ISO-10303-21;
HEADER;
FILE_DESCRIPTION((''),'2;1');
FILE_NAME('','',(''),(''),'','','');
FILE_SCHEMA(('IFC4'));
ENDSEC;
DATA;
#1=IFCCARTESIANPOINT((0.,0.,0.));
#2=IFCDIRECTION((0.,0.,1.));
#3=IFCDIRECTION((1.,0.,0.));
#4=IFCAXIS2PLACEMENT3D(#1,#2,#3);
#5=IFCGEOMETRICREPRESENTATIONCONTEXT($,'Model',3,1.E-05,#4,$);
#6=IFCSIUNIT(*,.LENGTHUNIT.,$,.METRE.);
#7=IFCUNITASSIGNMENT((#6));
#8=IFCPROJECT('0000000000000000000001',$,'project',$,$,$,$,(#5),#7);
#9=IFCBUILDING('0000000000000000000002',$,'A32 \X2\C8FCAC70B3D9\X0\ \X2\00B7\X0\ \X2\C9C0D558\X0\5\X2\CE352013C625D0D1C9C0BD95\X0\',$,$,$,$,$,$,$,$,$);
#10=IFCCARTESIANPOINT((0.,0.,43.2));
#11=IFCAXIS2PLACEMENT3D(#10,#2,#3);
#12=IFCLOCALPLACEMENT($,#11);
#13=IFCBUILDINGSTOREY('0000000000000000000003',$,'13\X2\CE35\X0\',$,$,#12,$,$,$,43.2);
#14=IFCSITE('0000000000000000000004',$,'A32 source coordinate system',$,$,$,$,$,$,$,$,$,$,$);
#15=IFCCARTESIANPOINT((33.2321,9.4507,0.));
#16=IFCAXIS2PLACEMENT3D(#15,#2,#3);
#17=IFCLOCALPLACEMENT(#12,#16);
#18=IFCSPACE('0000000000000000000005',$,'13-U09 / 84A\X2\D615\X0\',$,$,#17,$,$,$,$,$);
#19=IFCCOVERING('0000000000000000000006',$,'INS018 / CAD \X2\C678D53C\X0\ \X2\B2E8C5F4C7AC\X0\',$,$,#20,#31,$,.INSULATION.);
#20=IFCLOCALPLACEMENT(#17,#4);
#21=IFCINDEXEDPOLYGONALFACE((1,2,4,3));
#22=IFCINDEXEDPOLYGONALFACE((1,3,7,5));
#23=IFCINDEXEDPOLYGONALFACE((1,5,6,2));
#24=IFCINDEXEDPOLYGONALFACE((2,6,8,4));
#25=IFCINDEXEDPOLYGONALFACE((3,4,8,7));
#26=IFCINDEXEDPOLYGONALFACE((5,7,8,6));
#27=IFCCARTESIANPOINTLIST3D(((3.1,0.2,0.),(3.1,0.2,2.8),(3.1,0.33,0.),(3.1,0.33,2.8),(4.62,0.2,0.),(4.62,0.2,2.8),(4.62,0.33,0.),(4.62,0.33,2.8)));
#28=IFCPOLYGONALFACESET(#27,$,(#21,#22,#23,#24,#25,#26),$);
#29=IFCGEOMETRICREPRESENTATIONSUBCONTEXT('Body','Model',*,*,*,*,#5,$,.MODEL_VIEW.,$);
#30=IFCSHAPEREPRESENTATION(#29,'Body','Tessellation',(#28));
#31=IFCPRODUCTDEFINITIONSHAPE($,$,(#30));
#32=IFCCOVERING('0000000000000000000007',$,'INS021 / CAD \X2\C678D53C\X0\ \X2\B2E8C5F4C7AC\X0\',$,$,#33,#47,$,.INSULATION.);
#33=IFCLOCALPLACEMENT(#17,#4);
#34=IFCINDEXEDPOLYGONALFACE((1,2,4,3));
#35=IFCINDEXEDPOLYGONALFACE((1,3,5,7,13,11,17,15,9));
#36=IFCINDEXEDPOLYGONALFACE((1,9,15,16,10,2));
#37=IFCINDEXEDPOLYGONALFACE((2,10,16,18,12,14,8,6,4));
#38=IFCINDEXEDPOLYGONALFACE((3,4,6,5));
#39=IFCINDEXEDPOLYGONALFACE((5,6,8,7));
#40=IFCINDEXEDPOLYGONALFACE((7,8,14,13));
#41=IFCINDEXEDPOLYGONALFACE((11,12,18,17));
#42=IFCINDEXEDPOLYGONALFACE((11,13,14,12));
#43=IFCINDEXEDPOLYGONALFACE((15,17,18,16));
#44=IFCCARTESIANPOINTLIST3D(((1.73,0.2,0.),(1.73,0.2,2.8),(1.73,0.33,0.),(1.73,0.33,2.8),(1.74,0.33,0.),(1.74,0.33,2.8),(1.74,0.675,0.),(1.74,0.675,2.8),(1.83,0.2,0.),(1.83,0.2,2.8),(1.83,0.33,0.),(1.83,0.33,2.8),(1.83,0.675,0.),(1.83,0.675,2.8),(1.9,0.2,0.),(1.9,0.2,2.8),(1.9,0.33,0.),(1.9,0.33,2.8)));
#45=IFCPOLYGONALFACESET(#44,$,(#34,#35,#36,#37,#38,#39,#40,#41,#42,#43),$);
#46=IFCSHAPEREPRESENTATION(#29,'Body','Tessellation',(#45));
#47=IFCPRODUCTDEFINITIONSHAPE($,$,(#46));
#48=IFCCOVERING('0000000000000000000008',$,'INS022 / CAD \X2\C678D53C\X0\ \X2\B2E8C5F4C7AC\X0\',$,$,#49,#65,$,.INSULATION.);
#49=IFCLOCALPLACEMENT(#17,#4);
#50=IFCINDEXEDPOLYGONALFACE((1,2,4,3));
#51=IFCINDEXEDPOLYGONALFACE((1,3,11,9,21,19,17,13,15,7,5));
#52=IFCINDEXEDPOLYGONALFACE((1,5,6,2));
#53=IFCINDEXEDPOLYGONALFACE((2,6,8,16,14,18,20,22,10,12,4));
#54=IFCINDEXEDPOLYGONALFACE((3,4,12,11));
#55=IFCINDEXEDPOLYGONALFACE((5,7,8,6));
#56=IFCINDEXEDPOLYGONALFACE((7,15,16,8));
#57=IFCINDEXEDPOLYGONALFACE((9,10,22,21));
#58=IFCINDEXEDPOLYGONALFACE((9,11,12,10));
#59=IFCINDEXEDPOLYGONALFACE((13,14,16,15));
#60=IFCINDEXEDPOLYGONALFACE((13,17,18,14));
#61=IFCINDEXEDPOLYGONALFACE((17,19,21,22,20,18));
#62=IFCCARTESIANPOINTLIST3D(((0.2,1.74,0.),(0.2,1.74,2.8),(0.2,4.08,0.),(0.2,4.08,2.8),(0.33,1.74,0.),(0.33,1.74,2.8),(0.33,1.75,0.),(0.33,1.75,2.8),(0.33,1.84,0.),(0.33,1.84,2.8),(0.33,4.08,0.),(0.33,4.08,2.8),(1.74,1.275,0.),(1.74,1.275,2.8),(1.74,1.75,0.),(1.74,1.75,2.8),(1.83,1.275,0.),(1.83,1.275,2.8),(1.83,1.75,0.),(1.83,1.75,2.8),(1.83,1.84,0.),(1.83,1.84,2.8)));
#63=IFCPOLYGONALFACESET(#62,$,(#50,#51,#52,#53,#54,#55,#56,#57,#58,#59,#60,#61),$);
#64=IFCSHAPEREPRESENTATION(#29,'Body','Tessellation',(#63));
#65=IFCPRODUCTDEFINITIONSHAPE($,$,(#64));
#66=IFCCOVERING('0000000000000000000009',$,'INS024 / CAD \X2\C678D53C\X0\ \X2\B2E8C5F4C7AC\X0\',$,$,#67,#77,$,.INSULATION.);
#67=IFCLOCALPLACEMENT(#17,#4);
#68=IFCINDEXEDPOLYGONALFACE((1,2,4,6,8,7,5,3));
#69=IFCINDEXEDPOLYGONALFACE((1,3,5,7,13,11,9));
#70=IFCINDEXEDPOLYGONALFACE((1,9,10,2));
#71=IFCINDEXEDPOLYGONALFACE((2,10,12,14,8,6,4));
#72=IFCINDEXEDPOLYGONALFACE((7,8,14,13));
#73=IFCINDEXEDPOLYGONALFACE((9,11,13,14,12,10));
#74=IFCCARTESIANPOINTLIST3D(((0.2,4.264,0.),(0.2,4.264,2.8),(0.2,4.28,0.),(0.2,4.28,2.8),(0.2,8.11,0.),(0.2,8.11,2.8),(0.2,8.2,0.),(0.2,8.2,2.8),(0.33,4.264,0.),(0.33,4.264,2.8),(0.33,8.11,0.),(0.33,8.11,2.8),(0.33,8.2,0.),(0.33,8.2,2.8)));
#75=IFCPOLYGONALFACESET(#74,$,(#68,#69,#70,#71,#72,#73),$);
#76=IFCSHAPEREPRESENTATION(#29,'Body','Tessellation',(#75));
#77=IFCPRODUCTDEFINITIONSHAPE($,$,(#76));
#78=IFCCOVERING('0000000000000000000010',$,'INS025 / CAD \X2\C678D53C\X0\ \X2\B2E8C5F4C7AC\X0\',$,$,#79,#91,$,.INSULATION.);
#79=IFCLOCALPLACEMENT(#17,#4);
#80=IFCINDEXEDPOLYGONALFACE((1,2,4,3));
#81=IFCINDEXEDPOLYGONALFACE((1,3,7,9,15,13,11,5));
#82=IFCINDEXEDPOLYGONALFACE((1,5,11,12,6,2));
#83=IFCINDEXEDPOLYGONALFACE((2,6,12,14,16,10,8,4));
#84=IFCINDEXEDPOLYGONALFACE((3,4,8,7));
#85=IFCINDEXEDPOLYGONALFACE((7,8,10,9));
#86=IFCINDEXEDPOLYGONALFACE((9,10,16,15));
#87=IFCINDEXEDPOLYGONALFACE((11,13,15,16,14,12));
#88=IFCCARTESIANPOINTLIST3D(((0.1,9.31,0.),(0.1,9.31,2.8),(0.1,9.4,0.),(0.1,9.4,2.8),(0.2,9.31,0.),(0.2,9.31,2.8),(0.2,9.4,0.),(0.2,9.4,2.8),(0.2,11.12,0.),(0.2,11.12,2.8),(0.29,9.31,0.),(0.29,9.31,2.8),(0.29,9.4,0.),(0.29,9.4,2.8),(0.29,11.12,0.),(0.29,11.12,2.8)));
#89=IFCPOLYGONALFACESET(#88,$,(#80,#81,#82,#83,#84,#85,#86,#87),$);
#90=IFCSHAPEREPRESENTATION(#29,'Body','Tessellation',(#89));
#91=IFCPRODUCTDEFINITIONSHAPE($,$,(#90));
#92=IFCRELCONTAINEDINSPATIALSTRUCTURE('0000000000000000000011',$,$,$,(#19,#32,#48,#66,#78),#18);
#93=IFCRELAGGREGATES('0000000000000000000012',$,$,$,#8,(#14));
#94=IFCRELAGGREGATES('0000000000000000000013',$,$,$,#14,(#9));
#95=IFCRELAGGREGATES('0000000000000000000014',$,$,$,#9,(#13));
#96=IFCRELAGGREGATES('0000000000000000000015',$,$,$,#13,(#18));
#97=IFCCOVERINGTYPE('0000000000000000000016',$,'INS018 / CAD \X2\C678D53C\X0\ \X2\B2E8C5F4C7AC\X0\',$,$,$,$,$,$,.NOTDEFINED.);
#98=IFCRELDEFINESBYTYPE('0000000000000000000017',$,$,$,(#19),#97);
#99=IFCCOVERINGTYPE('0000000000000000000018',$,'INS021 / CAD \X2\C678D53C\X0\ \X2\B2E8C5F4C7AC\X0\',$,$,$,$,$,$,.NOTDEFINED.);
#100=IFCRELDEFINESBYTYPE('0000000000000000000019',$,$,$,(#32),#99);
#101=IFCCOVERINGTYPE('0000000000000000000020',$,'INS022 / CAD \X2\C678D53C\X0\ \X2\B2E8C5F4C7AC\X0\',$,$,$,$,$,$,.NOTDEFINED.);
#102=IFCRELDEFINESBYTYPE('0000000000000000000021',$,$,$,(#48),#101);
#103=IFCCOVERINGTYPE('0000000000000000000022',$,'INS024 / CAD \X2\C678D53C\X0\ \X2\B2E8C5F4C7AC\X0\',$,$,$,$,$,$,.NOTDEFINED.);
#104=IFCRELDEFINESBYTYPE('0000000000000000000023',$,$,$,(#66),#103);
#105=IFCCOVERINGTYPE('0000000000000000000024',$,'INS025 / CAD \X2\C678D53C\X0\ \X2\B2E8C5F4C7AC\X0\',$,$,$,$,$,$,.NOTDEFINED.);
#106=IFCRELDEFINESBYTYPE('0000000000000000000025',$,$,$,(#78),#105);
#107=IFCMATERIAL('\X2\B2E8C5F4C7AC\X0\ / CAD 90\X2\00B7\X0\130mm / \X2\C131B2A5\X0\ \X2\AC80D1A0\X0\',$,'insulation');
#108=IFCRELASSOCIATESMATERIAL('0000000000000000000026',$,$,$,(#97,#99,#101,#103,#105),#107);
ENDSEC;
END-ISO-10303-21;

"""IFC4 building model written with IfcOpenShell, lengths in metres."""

from ifc_helpers import new_model, si_unit, frame, origin, origin_with_axes, place, context, subcontext, project, spatial, polyline, outline, extrude, source, transform, mapped, material, type_object, type_shapes, element, save


model = new_model("IFC4")

# Units and contexts
model_context = context("Model", 3, precision=1e-05, world=origin_with_axes())
body_context = subcontext(model_context, "Body", "Model", "MODEL_VIEW")
ifc_project = project(units=[si_unit("LENGTHUNIT", "METRE")], contexts=[model_context])

# Site, building, storey, space
storey_placement = place(None, frame((0.0, 0.0, 43.2), z_axis=(0.0, 0.0, 1.0), x_axis=(1.0, 0.0, 0.0)))
space_placement = place(storey_placement, frame((33.2321, 9.4507, 0.0), z_axis=(0.0, 0.0, 1.0), x_axis=(1.0, 0.0, 0.0)))
site = spatial("IfcSite", under=ifc_project, Name="A32 source coordinate system")
building = spatial("IfcBuilding", under=site, Name="A32 주거동 · 지하5층–옥탑지붕")
storey = spatial("IfcBuildingStorey", under=building, at=storey_placement, Name="13층", Elevation=43.2)
space = spatial("IfcSpace", under=storey, at=space_placement, Name="13-U09 / 84A형")

# Coverings
ifc_material = material(Name="단열재 / CAD 90·130mm / 성능 검토", Category="insulation")
covering_type_1 = type_object("IfcCoveringType", Name="INS018 / CAD 외피 단열재", PredefinedType="NOTDEFINED", material=ifc_material)
shared_shape_1 = source(origin(), body_context, "Body", "SweptSolid", [
    extrude(outline(polyline([(3.1, 0.33), (4.62, 0.33), (4.62, 0.2), (3.1, 0.2), (3.1, 0.33)])), origin(), (0.0, 0.0, 1.0), 2.8),
])
type_shapes(covering_type_1, [shared_shape_1])
covering_1_placement = place(space_placement, origin_with_axes())
element("IfcCovering", 1, at=covering_1_placement, inside=space, type_object=covering_type_1, Name="INS018 / CAD 외피 단열재", PredefinedType="INSULATION", context=body_context, shape_type="MappedRepresentation", body=[
    mapped(shared_shape_1, transform((0.0, 0.0, 0.0), scale=1.0)),
])
covering_type_2 = type_object("IfcCoveringType", Name="INS021 / CAD 외피 단열재", PredefinedType="NOTDEFINED", material=ifc_material)
shared_shape_2 = source(origin(), body_context, "Body", "SweptSolid", [
    extrude(outline(polyline([(1.83, 0.33), (1.9, 0.33), (1.9, 0.2), (1.83, 0.2), (1.73, 0.2), (1.73, 0.33), (1.74, 0.33), (1.74, 0.675), (1.83, 0.675), (1.83, 0.33)])), origin(), (0.0, 0.0, 1.0), 2.8),
])
type_shapes(covering_type_2, [shared_shape_2])
covering_2_placement = place(space_placement, origin_with_axes())
element("IfcCovering", 2, at=covering_2_placement, inside=space, type_object=covering_type_2, Name="INS021 / CAD 외피 단열재", PredefinedType="INSULATION", context=body_context, shape_type="MappedRepresentation", body=[
    mapped(shared_shape_2, transform((0.0, 0.0, 0.0), scale=1.0)),
])
covering_type_3 = type_object("IfcCoveringType", Name="INS022 / CAD 외피 단열재", PredefinedType="NOTDEFINED", material=ifc_material)
shared_shape_3 = source(origin(), body_context, "Body", "SweptSolid", [
    extrude(outline(polyline([(1.83, 1.84), (1.83, 1.75), (1.83, 1.275), (1.74, 1.275), (1.74, 1.75), (0.33, 1.75), (0.33, 1.74), (0.2, 1.74), (0.2, 4.08), (0.33, 4.08), (0.33, 1.84), (1.83, 1.84)])), origin(), (0.0, 0.0, 1.0), 2.8),
])
type_shapes(covering_type_3, [shared_shape_3])
covering_3_placement = place(space_placement, origin_with_axes())
element("IfcCovering", 3, at=covering_3_placement, inside=space, type_object=covering_type_3, Name="INS022 / CAD 외피 단열재", PredefinedType="INSULATION", context=body_context, shape_type="MappedRepresentation", body=[
    mapped(shared_shape_3, transform((0.0, 0.0, 0.0), scale=1.0)),
])
covering_type_4 = type_object("IfcCoveringType", Name="INS024 / CAD 외피 단열재", PredefinedType="NOTDEFINED", material=ifc_material)
shared_shape_4 = source(origin(), body_context, "Body", "SweptSolid", [
    extrude(outline(polyline([(0.2, 8.11), (0.2, 8.2), (0.33, 8.2), (0.33, 8.11), (0.33, 4.264), (0.2, 4.264), (0.2, 4.28), (0.2, 8.11)])), origin(), (0.0, 0.0, 1.0), 2.8),
])
type_shapes(covering_type_4, [shared_shape_4])
covering_4_placement = place(space_placement, origin_with_axes())
element("IfcCovering", 4, at=covering_4_placement, inside=space, type_object=covering_type_4, Name="INS024 / CAD 외피 단열재", PredefinedType="INSULATION", context=body_context, shape_type="MappedRepresentation", body=[
    mapped(shared_shape_4, transform((0.0, 0.0, 0.0), scale=1.0)),
])
covering_type_5 = type_object("IfcCoveringType", Name="INS025 / CAD 외피 단열재", PredefinedType="NOTDEFINED", material=ifc_material)
shared_shape_5 = source(origin(), body_context, "Body", "SweptSolid", [
    extrude(outline(polyline([(0.2, 9.4), (0.2, 11.12), (0.29, 11.12), (0.29, 9.4), (0.29, 9.31), (0.2, 9.31), (0.1, 9.31), (0.1, 9.4), (0.2, 9.4)])), origin(), (0.0, 0.0, 1.0), 2.8),
])
type_shapes(covering_type_5, [shared_shape_5])
covering_5_placement = place(space_placement, origin_with_axes())
element("IfcCovering", 5, at=covering_5_placement, inside=space, type_object=covering_type_5, Name="INS025 / CAD 외피 단열재", PredefinedType="INSULATION", context=body_context, shape_type="MappedRepresentation", body=[
    mapped(shared_shape_5, transform((0.0, 0.0, 0.0), scale=1.0)),
])

save(model, "model.ifc")
